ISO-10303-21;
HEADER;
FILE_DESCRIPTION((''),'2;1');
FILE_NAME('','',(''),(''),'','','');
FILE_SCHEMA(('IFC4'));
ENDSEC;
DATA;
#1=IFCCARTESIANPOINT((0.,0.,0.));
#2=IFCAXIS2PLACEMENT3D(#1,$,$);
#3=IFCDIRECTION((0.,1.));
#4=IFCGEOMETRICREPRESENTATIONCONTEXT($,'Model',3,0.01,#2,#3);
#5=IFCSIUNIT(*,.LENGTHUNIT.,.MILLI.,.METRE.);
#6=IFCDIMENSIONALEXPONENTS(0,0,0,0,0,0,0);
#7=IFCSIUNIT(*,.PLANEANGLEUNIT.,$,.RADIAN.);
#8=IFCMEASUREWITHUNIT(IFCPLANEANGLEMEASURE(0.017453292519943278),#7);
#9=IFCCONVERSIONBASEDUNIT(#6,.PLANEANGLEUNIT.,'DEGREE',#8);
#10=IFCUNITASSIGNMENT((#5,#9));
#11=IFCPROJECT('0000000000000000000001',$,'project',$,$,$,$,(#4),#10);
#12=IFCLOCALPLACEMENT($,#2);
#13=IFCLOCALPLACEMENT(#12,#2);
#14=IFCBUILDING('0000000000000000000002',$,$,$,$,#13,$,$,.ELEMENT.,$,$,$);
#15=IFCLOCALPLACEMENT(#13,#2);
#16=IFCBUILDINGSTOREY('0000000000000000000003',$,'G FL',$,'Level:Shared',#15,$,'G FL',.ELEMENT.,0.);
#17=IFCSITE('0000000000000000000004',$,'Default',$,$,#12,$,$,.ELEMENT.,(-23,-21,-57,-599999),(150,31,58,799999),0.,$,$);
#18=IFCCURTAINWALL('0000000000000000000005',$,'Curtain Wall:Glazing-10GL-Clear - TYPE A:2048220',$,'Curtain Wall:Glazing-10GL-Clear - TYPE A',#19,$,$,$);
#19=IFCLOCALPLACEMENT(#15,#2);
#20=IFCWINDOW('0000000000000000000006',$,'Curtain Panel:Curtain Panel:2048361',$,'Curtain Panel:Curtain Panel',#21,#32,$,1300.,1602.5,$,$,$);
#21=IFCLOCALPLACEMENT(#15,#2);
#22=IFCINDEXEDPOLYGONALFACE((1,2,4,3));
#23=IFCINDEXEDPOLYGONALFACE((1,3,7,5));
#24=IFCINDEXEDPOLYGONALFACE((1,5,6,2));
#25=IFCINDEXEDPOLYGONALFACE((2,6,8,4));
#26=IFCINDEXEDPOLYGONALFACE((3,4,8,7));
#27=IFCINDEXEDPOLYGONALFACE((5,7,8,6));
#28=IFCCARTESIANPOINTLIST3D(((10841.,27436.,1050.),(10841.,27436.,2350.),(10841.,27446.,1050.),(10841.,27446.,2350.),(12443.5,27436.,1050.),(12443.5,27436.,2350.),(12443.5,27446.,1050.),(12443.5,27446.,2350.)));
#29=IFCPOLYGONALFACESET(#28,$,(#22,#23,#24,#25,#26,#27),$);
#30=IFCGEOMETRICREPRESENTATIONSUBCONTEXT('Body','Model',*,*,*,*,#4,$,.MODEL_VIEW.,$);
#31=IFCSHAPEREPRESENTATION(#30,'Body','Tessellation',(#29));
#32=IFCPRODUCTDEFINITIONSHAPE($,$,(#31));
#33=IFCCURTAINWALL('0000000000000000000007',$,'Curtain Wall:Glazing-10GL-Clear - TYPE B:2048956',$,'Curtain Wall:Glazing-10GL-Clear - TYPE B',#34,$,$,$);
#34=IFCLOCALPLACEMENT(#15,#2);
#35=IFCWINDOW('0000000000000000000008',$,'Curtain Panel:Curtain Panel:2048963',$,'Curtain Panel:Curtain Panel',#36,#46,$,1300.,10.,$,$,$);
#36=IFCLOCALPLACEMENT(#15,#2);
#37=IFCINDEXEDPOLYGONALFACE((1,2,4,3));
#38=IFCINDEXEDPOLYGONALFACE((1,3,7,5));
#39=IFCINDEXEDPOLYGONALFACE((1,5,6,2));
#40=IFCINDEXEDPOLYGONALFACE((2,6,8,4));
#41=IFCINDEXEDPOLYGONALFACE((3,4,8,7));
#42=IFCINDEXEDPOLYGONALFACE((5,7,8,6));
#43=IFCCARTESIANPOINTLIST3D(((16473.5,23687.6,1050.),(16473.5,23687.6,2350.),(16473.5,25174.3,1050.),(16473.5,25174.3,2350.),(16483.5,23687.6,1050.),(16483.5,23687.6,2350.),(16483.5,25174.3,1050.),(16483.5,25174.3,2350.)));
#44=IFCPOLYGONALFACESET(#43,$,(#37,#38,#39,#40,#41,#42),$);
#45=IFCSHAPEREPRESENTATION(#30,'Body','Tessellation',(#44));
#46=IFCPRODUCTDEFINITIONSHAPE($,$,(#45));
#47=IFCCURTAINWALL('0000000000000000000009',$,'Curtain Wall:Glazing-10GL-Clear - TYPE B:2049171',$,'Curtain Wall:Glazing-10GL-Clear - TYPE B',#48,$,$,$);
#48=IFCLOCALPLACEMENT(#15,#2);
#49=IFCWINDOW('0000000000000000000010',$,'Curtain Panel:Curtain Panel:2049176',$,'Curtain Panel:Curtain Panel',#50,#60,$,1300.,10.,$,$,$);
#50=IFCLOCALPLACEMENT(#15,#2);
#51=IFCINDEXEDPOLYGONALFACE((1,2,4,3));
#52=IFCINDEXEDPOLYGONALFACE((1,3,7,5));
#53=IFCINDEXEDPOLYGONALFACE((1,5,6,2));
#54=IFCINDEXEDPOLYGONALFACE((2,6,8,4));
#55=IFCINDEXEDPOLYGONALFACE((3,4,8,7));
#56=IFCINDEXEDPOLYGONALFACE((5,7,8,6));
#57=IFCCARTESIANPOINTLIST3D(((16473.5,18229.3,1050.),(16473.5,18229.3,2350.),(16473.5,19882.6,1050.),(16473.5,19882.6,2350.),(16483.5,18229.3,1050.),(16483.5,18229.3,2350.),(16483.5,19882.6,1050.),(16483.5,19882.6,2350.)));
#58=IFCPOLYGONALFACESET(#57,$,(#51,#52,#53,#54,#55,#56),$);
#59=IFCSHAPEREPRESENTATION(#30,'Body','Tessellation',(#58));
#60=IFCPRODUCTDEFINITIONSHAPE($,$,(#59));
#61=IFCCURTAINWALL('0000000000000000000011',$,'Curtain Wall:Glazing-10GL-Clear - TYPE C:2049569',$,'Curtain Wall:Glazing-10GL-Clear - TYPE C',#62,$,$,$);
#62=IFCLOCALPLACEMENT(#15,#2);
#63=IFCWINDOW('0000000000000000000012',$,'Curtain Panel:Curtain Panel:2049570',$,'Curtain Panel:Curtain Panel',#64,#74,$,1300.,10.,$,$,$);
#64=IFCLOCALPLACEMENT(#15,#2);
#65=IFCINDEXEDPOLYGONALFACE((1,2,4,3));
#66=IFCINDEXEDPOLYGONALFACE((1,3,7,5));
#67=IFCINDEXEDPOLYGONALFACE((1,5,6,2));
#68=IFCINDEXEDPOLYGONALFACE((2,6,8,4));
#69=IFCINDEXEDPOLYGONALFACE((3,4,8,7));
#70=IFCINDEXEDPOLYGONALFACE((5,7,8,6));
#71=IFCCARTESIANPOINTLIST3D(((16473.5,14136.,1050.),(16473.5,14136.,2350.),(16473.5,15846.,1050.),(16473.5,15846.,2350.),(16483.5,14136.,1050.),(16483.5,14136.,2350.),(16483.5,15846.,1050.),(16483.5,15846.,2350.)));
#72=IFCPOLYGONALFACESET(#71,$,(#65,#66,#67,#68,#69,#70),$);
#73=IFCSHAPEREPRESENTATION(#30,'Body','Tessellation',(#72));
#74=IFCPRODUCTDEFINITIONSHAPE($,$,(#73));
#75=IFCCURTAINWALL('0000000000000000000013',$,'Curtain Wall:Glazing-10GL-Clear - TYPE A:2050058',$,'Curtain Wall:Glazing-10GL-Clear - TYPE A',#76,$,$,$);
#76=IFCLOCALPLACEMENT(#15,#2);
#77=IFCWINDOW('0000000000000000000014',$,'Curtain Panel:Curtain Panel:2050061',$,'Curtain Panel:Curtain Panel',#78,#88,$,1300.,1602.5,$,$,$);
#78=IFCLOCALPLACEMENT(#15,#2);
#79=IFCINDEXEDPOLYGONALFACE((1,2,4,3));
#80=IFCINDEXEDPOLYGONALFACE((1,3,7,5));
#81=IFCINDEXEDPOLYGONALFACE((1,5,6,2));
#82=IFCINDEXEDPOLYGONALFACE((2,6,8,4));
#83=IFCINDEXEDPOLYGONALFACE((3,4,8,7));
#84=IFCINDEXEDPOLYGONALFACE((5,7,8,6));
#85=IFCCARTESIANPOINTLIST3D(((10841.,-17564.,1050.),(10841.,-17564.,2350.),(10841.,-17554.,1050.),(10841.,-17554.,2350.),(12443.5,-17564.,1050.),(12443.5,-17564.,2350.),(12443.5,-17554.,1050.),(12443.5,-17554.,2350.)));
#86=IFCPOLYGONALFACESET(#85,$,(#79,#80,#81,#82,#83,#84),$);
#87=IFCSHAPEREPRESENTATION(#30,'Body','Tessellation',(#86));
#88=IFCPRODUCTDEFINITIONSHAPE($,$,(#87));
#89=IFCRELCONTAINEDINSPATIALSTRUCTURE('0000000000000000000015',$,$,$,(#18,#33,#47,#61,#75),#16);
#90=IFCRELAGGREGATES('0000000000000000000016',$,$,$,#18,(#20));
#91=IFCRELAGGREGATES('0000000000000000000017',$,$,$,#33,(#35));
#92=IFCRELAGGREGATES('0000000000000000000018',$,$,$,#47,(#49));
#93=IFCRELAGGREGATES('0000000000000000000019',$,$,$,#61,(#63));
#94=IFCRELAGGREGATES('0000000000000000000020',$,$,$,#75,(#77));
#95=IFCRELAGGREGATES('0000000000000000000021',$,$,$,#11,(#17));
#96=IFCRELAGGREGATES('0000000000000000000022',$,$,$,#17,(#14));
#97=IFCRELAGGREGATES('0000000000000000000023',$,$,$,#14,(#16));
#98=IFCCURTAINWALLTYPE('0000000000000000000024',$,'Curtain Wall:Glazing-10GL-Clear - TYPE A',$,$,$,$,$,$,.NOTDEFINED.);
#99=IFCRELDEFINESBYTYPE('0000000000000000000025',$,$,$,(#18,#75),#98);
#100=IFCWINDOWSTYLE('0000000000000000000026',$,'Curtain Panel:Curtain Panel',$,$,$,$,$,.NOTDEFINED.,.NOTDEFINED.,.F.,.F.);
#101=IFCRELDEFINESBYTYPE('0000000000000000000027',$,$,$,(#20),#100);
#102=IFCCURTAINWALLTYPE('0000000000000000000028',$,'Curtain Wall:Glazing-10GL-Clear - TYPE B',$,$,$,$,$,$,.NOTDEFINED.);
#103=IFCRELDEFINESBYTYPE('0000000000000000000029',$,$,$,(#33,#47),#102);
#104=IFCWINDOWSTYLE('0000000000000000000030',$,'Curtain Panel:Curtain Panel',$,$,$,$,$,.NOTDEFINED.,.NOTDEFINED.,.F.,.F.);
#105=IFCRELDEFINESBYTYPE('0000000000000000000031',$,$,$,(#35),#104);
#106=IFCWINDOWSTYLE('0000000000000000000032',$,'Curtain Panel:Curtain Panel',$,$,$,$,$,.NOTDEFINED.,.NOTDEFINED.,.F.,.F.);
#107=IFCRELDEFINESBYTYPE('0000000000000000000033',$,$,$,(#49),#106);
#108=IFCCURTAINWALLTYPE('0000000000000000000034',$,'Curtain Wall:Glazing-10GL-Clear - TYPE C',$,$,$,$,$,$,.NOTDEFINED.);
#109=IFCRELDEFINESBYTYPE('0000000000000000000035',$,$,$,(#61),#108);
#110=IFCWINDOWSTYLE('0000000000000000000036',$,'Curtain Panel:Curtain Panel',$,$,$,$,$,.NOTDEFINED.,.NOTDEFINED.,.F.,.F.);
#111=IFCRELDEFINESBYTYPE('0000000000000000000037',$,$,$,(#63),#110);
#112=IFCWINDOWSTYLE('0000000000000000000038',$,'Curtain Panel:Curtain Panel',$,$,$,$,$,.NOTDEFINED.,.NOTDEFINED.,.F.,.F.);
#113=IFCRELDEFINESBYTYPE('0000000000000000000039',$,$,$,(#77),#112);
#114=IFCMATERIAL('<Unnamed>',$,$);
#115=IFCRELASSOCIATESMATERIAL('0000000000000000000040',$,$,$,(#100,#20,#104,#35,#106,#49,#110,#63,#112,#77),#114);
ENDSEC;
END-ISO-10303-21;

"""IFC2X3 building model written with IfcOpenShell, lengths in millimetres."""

from ifc_helpers import new_model, entity, si_unit, converted_unit, direction, frame, frame_2d, origin, origin_2d_with_axis, place, context, subcontext, project, spatial, rectangle, extrude, source, transform, mapped, material, type_object, type_shapes, element, aggregate, save


model = new_model("IFC2X3")

# Units and contexts
model_context = context("Model", 3, precision=0.01, world=origin(), true_north=direction((0.0, 1.0)))
body_context = subcontext(model_context, "Body", "Model", "MODEL_VIEW")
ifc_project = project(units=[si_unit("LENGTHUNIT", "METRE", prefix="MILLI"), converted_unit("PLANEANGLEUNIT", "DEGREE", entity("IfcPlaneAngleMeasure", 0.017453292519943278), si_unit("PLANEANGLEUNIT", "RADIAN"), dimensions=[0, 0, 0, 0, 0, 0, 0])], contexts=[model_context])

# Site, building, storey
site_placement = place(None, origin())
site = spatial("IfcSite", under=ifc_project, at=site_placement, Name="Default", CompositionType="ELEMENT", RefLatitude=(-23, -21, -57, -599999), RefLongitude=(150, 31, 58, 799999), RefElevation=0.0)
building_placement = place(site_placement, origin())
building = spatial("IfcBuilding", under=site, at=building_placement, CompositionType="ELEMENT")
storey_placement = place(building_placement, origin())
storey = spatial("IfcBuildingStorey", under=building, at=storey_placement, Name="G FL", ObjectType="Level:Shared", LongName="G FL", CompositionType="ELEMENT", Elevation=0.0)

# Curtain walls, windows
curtain_wall_type_1 = type_object("IfcCurtainWallType", Name="Curtain Wall:Glazing-10GL-Clear - TYPE A", PredefinedType="NOTDEFINED")
curtain_wall_1_placement = place(storey_placement, origin())
curtain_wall_1 = element("IfcCurtainWall", 1, at=curtain_wall_1_placement, inside=storey, type_object=curtain_wall_type_1, Name="Curtain Wall:Glazing-10GL-Clear - TYPE A:2048220", ObjectType="Curtain Wall:Glazing-10GL-Clear - TYPE A")
ifc_material_1 = material(Name="<Unnamed>")
window_style_1 = type_object("IfcWindowStyle", Name="Curtain Panel:Curtain Panel", ConstructionType="NOTDEFINED", OperationType="NOTDEFINED", ParameterTakesPrecedence=False, Sizeable=False, material=ifc_material_1)
shared_shape_1 = source(origin(), body_context, "Body", "SweptSolid", [
    extrude(rectangle(XDim=10.0, YDim=1602.5, at=frame_2d((0.0, 0.0), x_axis=(1.0, 0.0))), frame((11642.3, 27441.0, 1050.0), z_axis=(0.0, 0.0, 1.0), x_axis=(0.0, -1.0, 0.0)), (0.0, 0.0, 1.0), 1300.0),
])
type_shapes(window_style_1, [shared_shape_1])
window_1_placement = place(curtain_wall_1_placement, origin())
window_1 = element("IfcWindow", 2, at=window_1_placement, type_object=window_style_1, material=ifc_material_1, Name="Curtain Panel:Curtain Panel:2048361", ObjectType="Curtain Panel:Curtain Panel", OverallHeight=1300.0, OverallWidth=1602.5, context=body_context, shape_type="MappedRepresentation", body=[
    mapped(shared_shape_1, transform((0.0, 0.0, 0.0), scale=1.0)),
])
aggregate(curtain_wall_1, [window_1])
curtain_wall_type_2 = type_object("IfcCurtainWallType", Name="Curtain Wall:Glazing-10GL-Clear - TYPE B", PredefinedType="NOTDEFINED")
curtain_wall_2_placement = place(storey_placement, origin())
curtain_wall_2 = element("IfcCurtainWall", 3, at=curtain_wall_2_placement, inside=storey, type_object=curtain_wall_type_2, Name="Curtain Wall:Glazing-10GL-Clear - TYPE B:2048956", ObjectType="Curtain Wall:Glazing-10GL-Clear - TYPE B")
window_style_2 = type_object("IfcWindowStyle", Name="Curtain Panel:Curtain Panel", ConstructionType="NOTDEFINED", OperationType="NOTDEFINED", ParameterTakesPrecedence=False, Sizeable=False, material=ifc_material_1)
shared_shape_2 = source(origin(), body_context, "Body", "SweptSolid", [
    extrude(rectangle(XDim=10.0, YDim=1486.7, at=origin_2d_with_axis()), frame((16478.5, 24431.0, 1050.0)), (0.0, 0.0, 1.0), 1300.0),
])
type_shapes(window_style_2, [shared_shape_2])
window_2_placement = place(curtain_wall_2_placement, origin())
window_2 = element("IfcWindow", 4, at=window_2_placement, type_object=window_style_2, material=ifc_material_1, Name="Curtain Panel:Curtain Panel:2048963", ObjectType="Curtain Panel:Curtain Panel", OverallHeight=1300.0, OverallWidth=10.0, context=body_context, shape_type="MappedRepresentation", body=[
    mapped(shared_shape_2, transform((0.0, 0.0, 0.0), scale=1.0)),
])
aggregate(curtain_wall_2, [window_2])
curtain_wall_3_placement = place(storey_placement, origin())
curtain_wall_3 = element("IfcCurtainWall", 5, at=curtain_wall_3_placement, inside=storey, type_object=curtain_wall_type_2, Name="Curtain Wall:Glazing-10GL-Clear - TYPE B:2049171", ObjectType="Curtain Wall:Glazing-10GL-Clear - TYPE B")
window_style_3 = type_object("IfcWindowStyle", Name="Curtain Panel:Curtain Panel", ConstructionType="NOTDEFINED", OperationType="NOTDEFINED", ParameterTakesPrecedence=False, Sizeable=False, material=ifc_material_1)
shared_shape_3 = source(origin(), body_context, "Body", "SweptSolid", [
    extrude(rectangle(XDim=10.0, YDim=1653.3, at=frame_2d((0.0, 0.0), x_axis=(1.0, 0.0))), frame((16478.5, 19056.0, 1050.0), z_axis=(0.0, 0.0, 1.0), x_axis=(-1.0, 0.0, 0.0)), (0.0, 0.0, 1.0), 1300.0),
])
type_shapes(window_style_3, [shared_shape_3])
window_3_placement = place(curtain_wall_3_placement, origin())
window_3 = element("IfcWindow", 6, at=window_3_placement, type_object=window_style_3, material=ifc_material_1, Name="Curtain Panel:Curtain Panel:2049176", ObjectType="Curtain Panel:Curtain Panel", OverallHeight=1300.0, OverallWidth=10.0, context=body_context, shape_type="MappedRepresentation", body=[
    mapped(shared_shape_3, transform((0.0, 0.0, 0.0), scale=1.0)),
])
aggregate(curtain_wall_3, [window_3])
curtain_wall_type_3 = type_object("IfcCurtainWallType", Name="Curtain Wall:Glazing-10GL-Clear - TYPE C", PredefinedType="NOTDEFINED")
curtain_wall_4_placement = place(storey_placement, origin())
curtain_wall_4 = element("IfcCurtainWall", 7, at=curtain_wall_4_placement, inside=storey, type_object=curtain_wall_type_3, Name="Curtain Wall:Glazing-10GL-Clear - TYPE C:2049569", ObjectType="Curtain Wall:Glazing-10GL-Clear - TYPE C")
window_style_4 = type_object("IfcWindowStyle", Name="Curtain Panel:Curtain Panel", ConstructionType="NOTDEFINED", OperationType="NOTDEFINED", ParameterTakesPrecedence=False, Sizeable=False, material=ifc_material_1)
shared_shape_4 = source(origin(), body_context, "Body", "SweptSolid", [
    extrude(rectangle(XDim=10.0, YDim=1710.0, at=frame_2d((0.0, 0.0), x_axis=(1.0, 0.0))), frame((16478.5, 14991.0, 1050.0)), (0.0, 0.0, 1.0), 1300.0),
])
type_shapes(window_style_4, [shared_shape_4])
window_4_placement = place(curtain_wall_4_placement, origin())
window_4 = element("IfcWindow", 8, at=window_4_placement, type_object=window_style_4, material=ifc_material_1, Name="Curtain Panel:Curtain Panel:2049570", ObjectType="Curtain Panel:Curtain Panel", OverallHeight=1300.0, OverallWidth=10.0, context=body_context, shape_type="MappedRepresentation", body=[
    mapped(shared_shape_4, transform((0.0, 0.0, 0.0), scale=1.0)),
])
aggregate(curtain_wall_4, [window_4])
curtain_wall_5_placement = place(storey_placement, origin())
curtain_wall_5 = element("IfcCurtainWall", 9, at=curtain_wall_5_placement, inside=storey, type_object=curtain_wall_type_1, Name="Curtain Wall:Glazing-10GL-Clear - TYPE A:2050058", ObjectType="Curtain Wall:Glazing-10GL-Clear - TYPE A")
window_style_5 = type_object("IfcWindowStyle", Name="Curtain Panel:Curtain Panel", ConstructionType="NOTDEFINED", OperationType="NOTDEFINED", ParameterTakesPrecedence=False, Sizeable=False, material=ifc_material_1)
shared_shape_5 = source(origin(), body_context, "Body", "SweptSolid", [
    extrude(rectangle(XDim=10.0, YDim=1602.5, at=frame_2d((0.0, 0.0), x_axis=(1.0, 0.0))), frame((11642.3, -17559.0, 1050.0), z_axis=(0.0, 0.0, 1.0), x_axis=(0.0, -1.0, 0.0)), (0.0, 0.0, 1.0), 1300.0),
])
type_shapes(window_style_5, [shared_shape_5])
window_5_placement = place(curtain_wall_5_placement, origin())
window_5 = element("IfcWindow", 10, at=window_5_placement, type_object=window_style_5, material=ifc_material_1, Name="Curtain Panel:Curtain Panel:2050061", ObjectType="Curtain Panel:Curtain Panel", OverallHeight=1300.0, OverallWidth=1602.5, context=body_context, shape_type="MappedRepresentation", body=[
    mapped(shared_shape_5, transform((0.0, 0.0, 0.0), scale=1.0)),
])
aggregate(curtain_wall_5, [window_5])

save(model, "model.ifc")
